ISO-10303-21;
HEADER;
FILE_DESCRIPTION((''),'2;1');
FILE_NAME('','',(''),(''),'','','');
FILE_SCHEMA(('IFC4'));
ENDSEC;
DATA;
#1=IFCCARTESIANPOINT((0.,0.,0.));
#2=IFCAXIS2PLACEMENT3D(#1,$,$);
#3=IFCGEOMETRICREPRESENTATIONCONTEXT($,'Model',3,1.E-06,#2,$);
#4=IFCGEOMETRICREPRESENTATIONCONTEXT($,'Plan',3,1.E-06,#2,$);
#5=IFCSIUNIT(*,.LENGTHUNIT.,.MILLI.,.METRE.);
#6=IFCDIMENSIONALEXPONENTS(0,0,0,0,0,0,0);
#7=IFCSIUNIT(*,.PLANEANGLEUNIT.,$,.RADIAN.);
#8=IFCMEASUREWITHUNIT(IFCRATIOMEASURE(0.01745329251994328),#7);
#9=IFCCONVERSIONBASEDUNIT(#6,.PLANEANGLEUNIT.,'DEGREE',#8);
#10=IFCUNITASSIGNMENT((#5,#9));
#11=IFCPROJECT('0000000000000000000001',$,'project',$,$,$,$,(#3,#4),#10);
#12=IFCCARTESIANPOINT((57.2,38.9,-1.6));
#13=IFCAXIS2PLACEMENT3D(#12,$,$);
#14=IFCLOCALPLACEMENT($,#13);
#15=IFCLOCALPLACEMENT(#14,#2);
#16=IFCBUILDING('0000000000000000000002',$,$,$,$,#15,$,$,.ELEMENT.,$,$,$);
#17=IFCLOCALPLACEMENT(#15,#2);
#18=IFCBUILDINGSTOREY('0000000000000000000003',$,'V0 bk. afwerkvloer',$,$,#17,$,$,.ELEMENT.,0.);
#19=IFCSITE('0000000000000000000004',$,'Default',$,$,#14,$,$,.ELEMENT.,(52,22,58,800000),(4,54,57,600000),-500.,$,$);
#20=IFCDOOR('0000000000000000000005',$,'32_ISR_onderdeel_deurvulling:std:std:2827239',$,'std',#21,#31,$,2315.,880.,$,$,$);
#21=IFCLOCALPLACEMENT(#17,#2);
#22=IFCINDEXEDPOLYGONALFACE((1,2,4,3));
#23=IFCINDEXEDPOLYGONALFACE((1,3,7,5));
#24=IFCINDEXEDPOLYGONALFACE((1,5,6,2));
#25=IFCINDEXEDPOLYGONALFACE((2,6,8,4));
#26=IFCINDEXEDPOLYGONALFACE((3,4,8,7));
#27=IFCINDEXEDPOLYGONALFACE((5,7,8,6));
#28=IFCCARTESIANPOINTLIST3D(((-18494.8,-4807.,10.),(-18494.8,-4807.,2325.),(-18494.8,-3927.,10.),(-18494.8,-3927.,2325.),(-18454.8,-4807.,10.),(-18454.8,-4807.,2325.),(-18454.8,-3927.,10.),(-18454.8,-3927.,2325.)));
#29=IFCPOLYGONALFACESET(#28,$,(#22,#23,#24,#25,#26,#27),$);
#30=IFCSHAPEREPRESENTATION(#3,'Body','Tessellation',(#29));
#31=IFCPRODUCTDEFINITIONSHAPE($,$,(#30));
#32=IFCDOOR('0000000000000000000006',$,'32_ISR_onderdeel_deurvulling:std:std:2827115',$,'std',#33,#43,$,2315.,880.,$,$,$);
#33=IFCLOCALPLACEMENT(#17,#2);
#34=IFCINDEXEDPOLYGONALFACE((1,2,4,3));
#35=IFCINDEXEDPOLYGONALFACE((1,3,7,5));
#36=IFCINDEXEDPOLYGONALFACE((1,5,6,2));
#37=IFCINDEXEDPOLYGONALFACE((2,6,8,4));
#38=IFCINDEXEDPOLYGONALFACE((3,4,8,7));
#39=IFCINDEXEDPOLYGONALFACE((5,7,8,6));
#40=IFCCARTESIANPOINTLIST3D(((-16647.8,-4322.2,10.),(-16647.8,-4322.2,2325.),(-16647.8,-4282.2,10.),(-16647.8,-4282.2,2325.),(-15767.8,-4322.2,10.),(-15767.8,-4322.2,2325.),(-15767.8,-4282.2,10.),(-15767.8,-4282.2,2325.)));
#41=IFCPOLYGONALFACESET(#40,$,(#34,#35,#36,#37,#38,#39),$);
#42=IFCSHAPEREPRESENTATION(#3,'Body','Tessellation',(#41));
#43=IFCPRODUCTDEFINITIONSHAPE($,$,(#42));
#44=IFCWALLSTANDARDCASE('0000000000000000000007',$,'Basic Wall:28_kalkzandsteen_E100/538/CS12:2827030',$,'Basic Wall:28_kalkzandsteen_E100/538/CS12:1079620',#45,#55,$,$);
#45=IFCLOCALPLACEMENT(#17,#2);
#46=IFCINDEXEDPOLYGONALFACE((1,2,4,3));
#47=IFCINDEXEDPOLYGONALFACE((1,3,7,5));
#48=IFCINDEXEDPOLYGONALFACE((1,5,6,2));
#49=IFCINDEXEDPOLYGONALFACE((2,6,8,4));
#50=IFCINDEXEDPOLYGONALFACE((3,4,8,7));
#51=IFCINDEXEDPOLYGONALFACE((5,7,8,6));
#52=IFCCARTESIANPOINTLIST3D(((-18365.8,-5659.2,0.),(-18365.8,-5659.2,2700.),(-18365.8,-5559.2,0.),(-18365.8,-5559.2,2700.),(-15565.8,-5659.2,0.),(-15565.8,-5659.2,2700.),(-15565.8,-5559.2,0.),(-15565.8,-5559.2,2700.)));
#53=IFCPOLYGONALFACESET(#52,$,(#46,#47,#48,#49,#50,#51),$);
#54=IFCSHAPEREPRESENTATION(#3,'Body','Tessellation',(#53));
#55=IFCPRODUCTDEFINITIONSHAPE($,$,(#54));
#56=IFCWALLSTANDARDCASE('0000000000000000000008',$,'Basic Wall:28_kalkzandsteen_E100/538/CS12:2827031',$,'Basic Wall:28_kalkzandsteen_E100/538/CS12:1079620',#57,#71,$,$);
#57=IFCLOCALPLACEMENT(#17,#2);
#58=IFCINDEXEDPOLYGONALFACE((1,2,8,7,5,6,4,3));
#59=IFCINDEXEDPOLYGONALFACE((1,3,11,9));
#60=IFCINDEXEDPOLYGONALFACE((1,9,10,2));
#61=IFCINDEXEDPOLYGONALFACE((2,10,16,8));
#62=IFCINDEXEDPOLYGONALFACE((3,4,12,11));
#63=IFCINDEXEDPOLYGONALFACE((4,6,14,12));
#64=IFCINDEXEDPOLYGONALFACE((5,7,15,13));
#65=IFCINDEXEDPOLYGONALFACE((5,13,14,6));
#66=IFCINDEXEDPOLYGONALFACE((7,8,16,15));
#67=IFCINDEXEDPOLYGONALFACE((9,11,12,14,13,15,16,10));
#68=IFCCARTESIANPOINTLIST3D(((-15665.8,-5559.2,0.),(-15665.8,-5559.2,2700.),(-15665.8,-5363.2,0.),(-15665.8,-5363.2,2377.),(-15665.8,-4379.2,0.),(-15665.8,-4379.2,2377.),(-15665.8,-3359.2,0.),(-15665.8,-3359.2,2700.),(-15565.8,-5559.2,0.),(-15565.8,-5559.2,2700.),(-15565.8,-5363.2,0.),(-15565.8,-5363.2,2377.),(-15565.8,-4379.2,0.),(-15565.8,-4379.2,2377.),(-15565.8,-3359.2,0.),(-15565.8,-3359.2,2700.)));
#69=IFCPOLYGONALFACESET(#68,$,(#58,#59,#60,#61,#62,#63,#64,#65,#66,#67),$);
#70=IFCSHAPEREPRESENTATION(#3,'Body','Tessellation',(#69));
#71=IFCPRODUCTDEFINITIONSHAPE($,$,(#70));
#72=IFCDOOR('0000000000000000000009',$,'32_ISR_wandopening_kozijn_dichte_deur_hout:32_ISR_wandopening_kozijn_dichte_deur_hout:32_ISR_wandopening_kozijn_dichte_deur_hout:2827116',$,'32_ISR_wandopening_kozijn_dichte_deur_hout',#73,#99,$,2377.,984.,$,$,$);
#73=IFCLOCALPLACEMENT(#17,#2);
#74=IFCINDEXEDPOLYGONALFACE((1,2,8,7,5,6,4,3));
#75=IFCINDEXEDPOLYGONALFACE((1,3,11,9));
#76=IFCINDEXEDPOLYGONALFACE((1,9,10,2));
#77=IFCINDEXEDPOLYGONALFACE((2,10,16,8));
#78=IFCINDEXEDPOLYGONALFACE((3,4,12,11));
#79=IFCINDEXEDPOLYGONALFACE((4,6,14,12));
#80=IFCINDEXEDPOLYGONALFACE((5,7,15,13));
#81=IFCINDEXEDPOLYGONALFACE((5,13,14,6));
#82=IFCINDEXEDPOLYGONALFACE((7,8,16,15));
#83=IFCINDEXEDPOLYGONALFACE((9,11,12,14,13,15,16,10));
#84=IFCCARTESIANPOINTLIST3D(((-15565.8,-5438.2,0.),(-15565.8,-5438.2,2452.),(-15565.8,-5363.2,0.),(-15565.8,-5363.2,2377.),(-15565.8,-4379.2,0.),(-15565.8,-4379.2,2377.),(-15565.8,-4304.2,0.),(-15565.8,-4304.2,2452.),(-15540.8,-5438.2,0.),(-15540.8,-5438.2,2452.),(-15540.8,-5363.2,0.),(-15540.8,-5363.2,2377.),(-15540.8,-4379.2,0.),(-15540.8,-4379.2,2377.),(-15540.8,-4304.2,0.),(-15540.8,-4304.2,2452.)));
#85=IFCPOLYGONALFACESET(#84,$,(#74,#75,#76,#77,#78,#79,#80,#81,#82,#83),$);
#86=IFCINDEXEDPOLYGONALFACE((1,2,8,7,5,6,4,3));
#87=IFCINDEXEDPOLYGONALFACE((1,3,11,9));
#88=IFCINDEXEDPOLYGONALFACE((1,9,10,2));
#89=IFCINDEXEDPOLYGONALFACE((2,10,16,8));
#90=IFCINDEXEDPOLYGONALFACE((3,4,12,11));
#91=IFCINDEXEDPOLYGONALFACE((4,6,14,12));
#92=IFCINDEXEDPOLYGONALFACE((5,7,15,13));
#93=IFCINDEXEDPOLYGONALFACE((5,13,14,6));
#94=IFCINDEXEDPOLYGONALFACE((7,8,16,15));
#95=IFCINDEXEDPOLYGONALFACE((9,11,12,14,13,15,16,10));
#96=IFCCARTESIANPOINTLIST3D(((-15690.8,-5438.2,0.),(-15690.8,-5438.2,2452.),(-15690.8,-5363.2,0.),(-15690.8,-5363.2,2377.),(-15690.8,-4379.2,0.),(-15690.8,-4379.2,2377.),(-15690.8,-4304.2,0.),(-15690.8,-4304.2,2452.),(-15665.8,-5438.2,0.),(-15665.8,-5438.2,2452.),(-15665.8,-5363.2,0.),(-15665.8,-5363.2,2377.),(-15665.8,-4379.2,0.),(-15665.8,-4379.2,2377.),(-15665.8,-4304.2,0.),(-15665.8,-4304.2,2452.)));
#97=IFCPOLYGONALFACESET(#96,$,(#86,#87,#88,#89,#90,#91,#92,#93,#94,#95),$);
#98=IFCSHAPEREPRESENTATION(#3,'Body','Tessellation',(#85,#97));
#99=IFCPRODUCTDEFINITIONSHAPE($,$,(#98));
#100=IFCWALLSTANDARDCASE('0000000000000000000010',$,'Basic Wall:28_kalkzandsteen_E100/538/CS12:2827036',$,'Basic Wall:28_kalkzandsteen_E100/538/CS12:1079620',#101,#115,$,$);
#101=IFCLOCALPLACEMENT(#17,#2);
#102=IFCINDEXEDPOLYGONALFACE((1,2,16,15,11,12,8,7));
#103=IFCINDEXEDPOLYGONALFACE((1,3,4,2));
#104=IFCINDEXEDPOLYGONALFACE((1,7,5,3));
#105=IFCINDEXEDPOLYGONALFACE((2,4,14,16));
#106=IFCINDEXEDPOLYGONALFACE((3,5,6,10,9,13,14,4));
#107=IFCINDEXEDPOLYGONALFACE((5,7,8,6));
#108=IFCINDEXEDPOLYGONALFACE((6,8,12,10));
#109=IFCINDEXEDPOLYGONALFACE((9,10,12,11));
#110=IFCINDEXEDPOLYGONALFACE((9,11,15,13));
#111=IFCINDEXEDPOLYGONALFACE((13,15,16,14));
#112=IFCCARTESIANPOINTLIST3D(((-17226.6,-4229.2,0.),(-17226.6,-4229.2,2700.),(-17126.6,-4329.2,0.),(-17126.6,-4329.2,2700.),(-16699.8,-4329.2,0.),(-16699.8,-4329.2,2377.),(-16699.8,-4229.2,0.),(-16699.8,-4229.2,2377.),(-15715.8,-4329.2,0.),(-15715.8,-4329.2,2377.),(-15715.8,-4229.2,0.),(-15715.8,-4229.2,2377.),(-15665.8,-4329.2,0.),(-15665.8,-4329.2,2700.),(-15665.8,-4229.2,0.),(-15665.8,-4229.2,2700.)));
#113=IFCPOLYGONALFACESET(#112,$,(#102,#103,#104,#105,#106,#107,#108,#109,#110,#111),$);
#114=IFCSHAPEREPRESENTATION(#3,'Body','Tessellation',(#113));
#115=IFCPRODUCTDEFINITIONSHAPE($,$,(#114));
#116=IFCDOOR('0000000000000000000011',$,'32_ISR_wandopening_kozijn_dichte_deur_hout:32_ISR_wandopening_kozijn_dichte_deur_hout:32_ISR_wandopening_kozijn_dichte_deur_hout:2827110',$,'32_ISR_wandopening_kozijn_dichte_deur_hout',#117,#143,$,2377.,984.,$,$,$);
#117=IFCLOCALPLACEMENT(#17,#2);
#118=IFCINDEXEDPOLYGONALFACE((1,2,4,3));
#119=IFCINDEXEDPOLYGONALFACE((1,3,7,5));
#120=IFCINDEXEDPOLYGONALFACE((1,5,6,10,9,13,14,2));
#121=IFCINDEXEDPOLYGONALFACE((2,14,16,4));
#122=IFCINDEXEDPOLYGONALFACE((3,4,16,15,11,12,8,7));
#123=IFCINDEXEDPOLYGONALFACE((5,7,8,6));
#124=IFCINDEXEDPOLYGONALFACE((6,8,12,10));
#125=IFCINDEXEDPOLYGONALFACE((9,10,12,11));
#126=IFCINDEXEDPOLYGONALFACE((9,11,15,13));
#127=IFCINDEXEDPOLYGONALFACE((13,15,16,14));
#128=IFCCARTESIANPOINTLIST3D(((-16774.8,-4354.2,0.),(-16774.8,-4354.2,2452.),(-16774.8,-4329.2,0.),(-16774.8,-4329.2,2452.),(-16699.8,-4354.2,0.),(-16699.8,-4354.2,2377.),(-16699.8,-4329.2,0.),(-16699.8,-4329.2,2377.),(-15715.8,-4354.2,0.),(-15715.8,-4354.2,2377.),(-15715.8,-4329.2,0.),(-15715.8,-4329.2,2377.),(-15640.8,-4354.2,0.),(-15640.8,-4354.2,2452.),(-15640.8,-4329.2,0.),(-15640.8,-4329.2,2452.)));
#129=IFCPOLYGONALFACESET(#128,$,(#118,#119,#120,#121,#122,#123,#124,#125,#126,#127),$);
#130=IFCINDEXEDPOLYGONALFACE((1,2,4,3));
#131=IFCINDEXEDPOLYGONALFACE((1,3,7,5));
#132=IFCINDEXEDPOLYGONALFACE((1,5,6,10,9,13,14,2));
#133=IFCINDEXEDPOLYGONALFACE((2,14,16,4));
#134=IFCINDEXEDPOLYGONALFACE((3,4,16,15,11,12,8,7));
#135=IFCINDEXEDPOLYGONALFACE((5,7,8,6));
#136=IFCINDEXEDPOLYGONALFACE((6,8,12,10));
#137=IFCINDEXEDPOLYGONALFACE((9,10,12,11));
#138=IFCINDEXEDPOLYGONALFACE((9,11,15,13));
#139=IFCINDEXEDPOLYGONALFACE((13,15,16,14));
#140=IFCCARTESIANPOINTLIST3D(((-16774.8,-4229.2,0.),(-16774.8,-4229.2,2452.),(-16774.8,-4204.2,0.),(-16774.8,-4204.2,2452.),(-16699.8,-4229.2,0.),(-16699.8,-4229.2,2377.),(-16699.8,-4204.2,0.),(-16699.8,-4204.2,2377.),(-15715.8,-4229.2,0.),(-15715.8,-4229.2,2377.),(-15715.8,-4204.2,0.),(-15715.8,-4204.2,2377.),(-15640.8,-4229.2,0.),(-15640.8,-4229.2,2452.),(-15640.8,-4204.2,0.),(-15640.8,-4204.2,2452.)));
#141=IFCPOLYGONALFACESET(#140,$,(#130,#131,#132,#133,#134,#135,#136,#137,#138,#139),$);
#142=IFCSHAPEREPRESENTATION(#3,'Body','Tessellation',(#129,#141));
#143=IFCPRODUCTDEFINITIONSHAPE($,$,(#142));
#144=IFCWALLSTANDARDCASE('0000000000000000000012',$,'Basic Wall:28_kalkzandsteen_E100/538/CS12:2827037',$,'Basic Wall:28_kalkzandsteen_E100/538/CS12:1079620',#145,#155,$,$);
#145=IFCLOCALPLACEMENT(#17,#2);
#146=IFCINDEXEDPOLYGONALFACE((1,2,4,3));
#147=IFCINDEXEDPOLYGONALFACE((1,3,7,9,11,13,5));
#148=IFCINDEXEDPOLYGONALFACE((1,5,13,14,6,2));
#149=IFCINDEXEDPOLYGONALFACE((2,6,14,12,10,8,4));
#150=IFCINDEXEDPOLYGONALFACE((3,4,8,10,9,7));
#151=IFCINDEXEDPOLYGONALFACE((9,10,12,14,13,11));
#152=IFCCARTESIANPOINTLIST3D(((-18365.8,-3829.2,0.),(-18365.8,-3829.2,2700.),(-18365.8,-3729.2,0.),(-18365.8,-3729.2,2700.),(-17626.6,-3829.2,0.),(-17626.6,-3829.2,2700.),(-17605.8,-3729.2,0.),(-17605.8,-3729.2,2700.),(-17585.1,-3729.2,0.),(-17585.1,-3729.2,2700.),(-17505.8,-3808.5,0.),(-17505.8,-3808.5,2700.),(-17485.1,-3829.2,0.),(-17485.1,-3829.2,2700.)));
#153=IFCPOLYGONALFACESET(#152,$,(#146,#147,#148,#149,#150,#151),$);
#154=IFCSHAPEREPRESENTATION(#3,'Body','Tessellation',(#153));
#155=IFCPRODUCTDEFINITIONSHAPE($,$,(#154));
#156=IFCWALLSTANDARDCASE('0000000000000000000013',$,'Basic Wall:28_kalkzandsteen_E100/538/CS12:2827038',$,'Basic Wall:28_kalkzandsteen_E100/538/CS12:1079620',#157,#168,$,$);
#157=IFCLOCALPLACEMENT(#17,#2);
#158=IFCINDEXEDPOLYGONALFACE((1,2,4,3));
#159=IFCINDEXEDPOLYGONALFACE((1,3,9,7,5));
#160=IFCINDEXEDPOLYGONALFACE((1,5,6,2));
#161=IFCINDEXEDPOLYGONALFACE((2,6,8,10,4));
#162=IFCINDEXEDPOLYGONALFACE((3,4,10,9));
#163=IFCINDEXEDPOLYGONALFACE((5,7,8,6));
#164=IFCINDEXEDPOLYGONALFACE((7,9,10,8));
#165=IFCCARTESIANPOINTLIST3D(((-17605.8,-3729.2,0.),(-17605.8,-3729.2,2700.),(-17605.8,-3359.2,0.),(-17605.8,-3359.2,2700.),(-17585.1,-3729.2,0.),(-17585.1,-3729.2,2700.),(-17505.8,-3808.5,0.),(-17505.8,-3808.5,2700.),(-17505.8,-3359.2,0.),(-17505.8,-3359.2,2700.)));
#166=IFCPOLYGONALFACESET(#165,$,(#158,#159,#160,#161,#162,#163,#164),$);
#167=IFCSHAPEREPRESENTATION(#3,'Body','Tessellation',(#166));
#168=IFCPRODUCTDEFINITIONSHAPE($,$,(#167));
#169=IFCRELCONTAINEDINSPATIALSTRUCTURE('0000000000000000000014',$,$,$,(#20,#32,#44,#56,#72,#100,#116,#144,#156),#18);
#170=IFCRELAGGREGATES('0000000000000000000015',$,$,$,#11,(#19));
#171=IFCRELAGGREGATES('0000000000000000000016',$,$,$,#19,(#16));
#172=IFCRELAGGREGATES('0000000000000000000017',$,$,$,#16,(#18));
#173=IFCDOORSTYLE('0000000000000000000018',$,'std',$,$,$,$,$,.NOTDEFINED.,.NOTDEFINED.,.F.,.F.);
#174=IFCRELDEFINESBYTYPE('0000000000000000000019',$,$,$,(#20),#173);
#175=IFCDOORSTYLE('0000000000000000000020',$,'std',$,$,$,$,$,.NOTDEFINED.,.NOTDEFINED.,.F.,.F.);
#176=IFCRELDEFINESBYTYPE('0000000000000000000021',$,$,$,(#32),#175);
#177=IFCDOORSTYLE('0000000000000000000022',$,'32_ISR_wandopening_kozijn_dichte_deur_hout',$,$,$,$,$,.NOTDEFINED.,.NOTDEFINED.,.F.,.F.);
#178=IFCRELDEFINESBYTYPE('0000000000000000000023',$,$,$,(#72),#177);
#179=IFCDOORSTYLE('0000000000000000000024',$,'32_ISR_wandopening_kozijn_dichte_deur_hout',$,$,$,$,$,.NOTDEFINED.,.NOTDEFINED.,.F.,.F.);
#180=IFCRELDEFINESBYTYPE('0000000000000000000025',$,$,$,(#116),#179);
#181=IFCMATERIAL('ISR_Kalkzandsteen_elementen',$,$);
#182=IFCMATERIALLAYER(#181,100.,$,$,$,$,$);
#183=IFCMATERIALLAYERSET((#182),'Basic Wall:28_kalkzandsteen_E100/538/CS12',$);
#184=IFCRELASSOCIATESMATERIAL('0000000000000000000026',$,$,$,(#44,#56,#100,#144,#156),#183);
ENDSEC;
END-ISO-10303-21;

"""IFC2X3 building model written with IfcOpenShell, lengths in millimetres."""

from ifc_helpers import new_model, entity, si_unit, converted_unit, frame, frame_2d, origin, origin_2d_with_axis, place, context, project, spatial, polyline, rectangle, outline, extrude, source, transform, mapped, material, layer, layer_set, layer_usage, type_object, type_shapes, element, fill, save


model = new_model("IFC2X3")

# Units and contexts
model_context = context("Model", 3, precision=1e-06, world=origin())
plan_context = context("Plan", 3, precision=1e-06, world=origin())
ifc_project = project(units=[si_unit("LENGTHUNIT", "METRE", prefix="MILLI"), converted_unit("PLANEANGLEUNIT", "DEGREE", entity("IfcRatioMeasure", 0.01745329251994328), si_unit("PLANEANGLEUNIT", "RADIAN"), dimensions=[0, 0, 0, 0, 0, 0, 0])], contexts=[model_context, plan_context])

# Site, building, storey
site_placement = place(None, frame((57.2, 38.9, -1.6)))
site = spatial("IfcSite", under=ifc_project, at=site_placement, Name="Default", CompositionType="ELEMENT", RefLatitude=(52, 22, 58, 800000), RefLongitude=(4, 54, 57, 600000), RefElevation=-500.0)
building_placement = place(site_placement, origin())
building = spatial("IfcBuilding", under=site, at=building_placement, CompositionType="ELEMENT")
storey_placement = place(building_placement, origin())
storey = spatial("IfcBuildingStorey", under=building, at=storey_placement, Name="V0 bk. afwerkvloer", CompositionType="ELEMENT", Elevation=0.0)

# Doors
door_style_1 = type_object("IfcDoorStyle", Name="std", ConstructionType="NOTDEFINED", OperationType="NOTDEFINED", ParameterTakesPrecedence=False, Sizeable=False)
shared_shape_1 = source(origin(), model_context, "Body", "SweptSolid", [
    extrude(rectangle(XDim=880.0, YDim=40.0, at=origin_2d_with_axis()), frame((0.0, 34.0, 0.0)), (0.0, 0.0, 1.0), 2315.0),
])
type_shapes(door_style_1, [shared_shape_1])
door_1_placement = place(storey_placement, frame((-18440.8, -4367.0, 10.0), z_axis=(0.0, 0.0, 1.0), x_axis=(0.0, 1.0, 0.0)))
element("IfcDoor", 1, at=door_1_placement, inside=storey, type_object=door_style_1, Name="32_ISR_onderdeel_deurvulling:std:std:2827239", ObjectType="std", OverallHeight=2315.0, OverallWidth=880.0, context=model_context, shape_type="MappedRepresentation", body=[
    mapped(shared_shape_1, transform((0.0, 0.0, 0.0), scale=1.0)),
])
door_style_2 = type_object("IfcDoorStyle", Name="std", ConstructionType="NOTDEFINED", OperationType="NOTDEFINED", ParameterTakesPrecedence=False, Sizeable=False)
shared_shape_2 = source(origin(), model_context, "Body", "SweptSolid", [
    extrude(rectangle(XDim=40.0, YDim=880.0, at=origin_2d_with_axis()), frame((0.0, -34.0, 0.0), z_axis=(0.0, 0.0, 1.0), x_axis=(0.0, -1.0, 0.0)), (0.0, 0.0, 1.0), 2315.0),
])
type_shapes(door_style_2, [shared_shape_2])
door_2_placement = place(storey_placement, frame((-16207.8, -4336.2, 10.0), z_axis=(0.0, 0.0, 1.0), x_axis=(-1.0, 0.0, 0.0)))
element("IfcDoor", 2, at=door_2_placement, inside=storey, type_object=door_style_2, Name="32_ISR_onderdeel_deurvulling:std:std:2827115", ObjectType="std", OverallHeight=2315.0, OverallWidth=880.0, context=model_context, shape_type="MappedRepresentation", body=[
    mapped(shared_shape_2, transform((0.0, 0.0, 0.0), scale=1.0)),
])

# Shared definitions
ifc_material_1 = material(Name="ISR_Kalkzandsteen_elementen")
ifc_layer_1 = layer(ifc_material_1, 100.0)
ifc_layer_set_1 = layer_set([ifc_layer_1], Name="Basic Wall:28_kalkzandsteen_E100/538/CS12")

# Wall
ifc_layer_usage_1 = layer_usage(ifc_layer_set_1, "AXIS2", "POSITIVE", -50.0)
wall_1_placement = place(storey_placement, frame((-18365.8, -5609.2, 0.0)))
element("IfcWallStandardCase", 3, at=wall_1_placement, inside=storey, material=ifc_layer_usage_1, Name="Basic Wall:28_kalkzandsteen_E100/538/CS12:2827030", ObjectType="Basic Wall:28_kalkzandsteen_E100/538/CS12:1079620", context=model_context, shape_type="SweptSolid", body=[
    extrude(rectangle(XDim=2800.0, YDim=100.0, at=frame_2d((1400.0, 0.0), x_axis=(-1.0, 0.0))), origin(), (0.0, 0.0, 1.0), 2700.0),
])

# Walls, openings, doors
ifc_layer_usage_2 = layer_usage(ifc_layer_set_1, "AXIS2", "POSITIVE", -50.0)
wall_2_placement = place(storey_placement, frame((-15615.8, -5559.2, 0.0), z_axis=(0.0, 0.0, 1.0), x_axis=(0.0, 1.0, 0.0)))
wall_2 = element("IfcWallStandardCase", 4, at=wall_2_placement, inside=storey, material=ifc_layer_usage_2, Name="Basic Wall:28_kalkzandsteen_E100/538/CS12:2827031", ObjectType="Basic Wall:28_kalkzandsteen_E100/538/CS12:1079620", context=model_context, shape_type="SweptSolid", body=[
    extrude(rectangle(XDim=2200.0, YDim=100.0, at=frame_2d((1100.0, 0.0), x_axis=(-1.0, 0.0))), origin(), (0.0, 0.0, 1.0), 2700.0),
])
opening_1_placement = place(wall_2_placement, frame((1180.0, 50.0, 0.0)))
opening_1 = element("IfcOpeningElement", 5, at=opening_1_placement, cuts=wall_2, ObjectType="Opening", context=model_context, shape_type="SweptSolid", body=[
    extrude(rectangle(XDim=2377.0, YDim=984.0, at=frame_2d((1188.5, 492.0), x_axis=(1.0, 0.0))), frame((0.0, 0.0, 0.0), z_axis=(0.0, -1.0, 0.0), x_axis=(0.0, 0.0, 1.0)), (0.0, 0.0, 1.0), 100.0),
])
door_style_3 = type_object("IfcDoorStyle", Name="32_ISR_wandopening_kozijn_dichte_deur_hout", ConstructionType="NOTDEFINED", OperationType="NOTDEFINED", ParameterTakesPrecedence=False, Sizeable=False)
shared_shape_3 = source(origin(), model_context, "Body", "SweptSolid", [
    extrude(outline(polyline([(-1169.7, 492.0), (1207.2, 492.0), (1207.2, 567.0), (-1244.7, 567.0), (-1244.7, -567.0), (1207.2, -567.0), (1207.2, -492.0), (-1169.7, -492.0), (-1169.7, 492.0)])), frame((1202.0, 125.0, 1207.2), z_axis=(0.0, -1.0, 0.0), x_axis=(0.0, 0.0, -1.0)), (0.0, 0.0, 1.0), 25.0),
    extrude(outline(polyline([(-567.0, -1244.7), (567.0, -1244.7), (567.0, 1207.2), (492.0, 1207.2), (492.0, -1169.7), (-492.0, -1169.7), (-492.0, 1207.2), (-567.0, 1207.2), (-567.0, -1244.7)])), frame((1202.0, 0.0, 1207.2), z_axis=(0.0, -1.0, 0.0), x_axis=(-1.0, 0.0, 0.0)), (0.0, 0.0, 1.0), 25.0),
])
type_shapes(door_style_3, [shared_shape_3])
door_3_placement = place(opening_1_placement, frame((710.0, 0.0, 0.0), z_axis=(0.0, 0.0, 1.0), x_axis=(-1.0, 0.0, 0.0)))
door_3 = element("IfcDoor", 6, at=door_3_placement, inside=storey, type_object=door_style_3, Name="32_ISR_wandopening_kozijn_dichte_deur_hout:32_ISR_wandopening_kozijn_dichte_deur_hout:32_ISR_wandopening_kozijn_dichte_deur_hout:2827116", ObjectType="32_ISR_wandopening_kozijn_dichte_deur_hout", OverallHeight=2377.0, OverallWidth=984.0, context=model_context, shape_type="MappedRepresentation", body=[
    mapped(shared_shape_3, transform((0.0, 0.0, 0.0), scale=1.0)),
])
fill(opening_1, door_3)
ifc_layer_usage_3 = layer_usage(ifc_layer_set_1, "AXIS2", "POSITIVE", -50.0)
wall_3_placement = place(storey_placement, frame((-15665.8, -4279.2, 0.0), z_axis=(0.0, 0.0, 1.0), x_axis=(-1.0, 0.0, 0.0)))
wall_3 = element("IfcWallStandardCase", 7, at=wall_3_placement, inside=storey, material=ifc_layer_usage_3, Name="Basic Wall:28_kalkzandsteen_E100/538/CS12:2827036", ObjectType="Basic Wall:28_kalkzandsteen_E100/538/CS12:1079620", context=model_context, shape_type="SweptSolid", body=[
    extrude(outline(polyline([(0.0, -50.0), (1419.3, -50.0), (1560.7, -50.0), (1460.7, 50.0), (0.0, 50.0), (0.0, -50.0)])), origin(), (0.0, 0.0, 1.0), 2700.0),
])
opening_2_placement = place(wall_3_placement, frame((50.0, -50.0, 0.0)))
opening_2 = element("IfcOpeningElement", 8, at=opening_2_placement, cuts=wall_3, ObjectType="Opening", context=model_context, shape_type="SweptSolid", body=[
    extrude(rectangle(XDim=2377.0, YDim=984.0, at=frame_2d((1188.5, 492.0), x_axis=(1.0, 0.0))), frame((0.0, 0.0, 0.0), z_axis=(0.0, 1.0, 0.0), x_axis=(0.0, 0.0, 1.0)), (0.0, 0.0, 1.0), 100.0),
])
door_style_4 = type_object("IfcDoorStyle", Name="32_ISR_wandopening_kozijn_dichte_deur_hout", ConstructionType="NOTDEFINED", OperationType="NOTDEFINED", ParameterTakesPrecedence=False, Sizeable=False)
shared_shape_4 = source(origin(), model_context, "Body", "SweptSolid", [
    extrude(outline(polyline([(-1169.7, 492.0), (1207.2, 492.0), (1207.2, 567.0), (-1244.7, 567.0), (-1244.7, -567.0), (1207.2, -567.0), (1207.2, -492.0), (-1169.7, -492.0), (-1169.7, 492.0)])), frame((492.0, 100.0, 1207.2), z_axis=(0.0, 1.0, 0.0), x_axis=(0.0, 0.0, -1.0)), (0.0, 0.0, 1.0), 25.0),
    extrude(outline(polyline([(-567.0, -1244.7), (567.0, -1244.7), (567.0, 1207.2), (492.0, 1207.2), (492.0, -1169.7), (-492.0, -1169.7), (-492.0, 1207.2), (-567.0, 1207.2), (-567.0, -1244.7)])), frame((492.0, -25.0, 1207.2), z_axis=(0.0, 1.0, 0.0), x_axis=(1.0, 0.0, 0.0)), (0.0, 0.0, 1.0), 25.0),
])
type_shapes(door_style_4, [shared_shape_4])
door_4_placement = place(opening_2_placement, origin())
door_4 = element("IfcDoor", 9, at=door_4_placement, inside=storey, type_object=door_style_4, Name="32_ISR_wandopening_kozijn_dichte_deur_hout:32_ISR_wandopening_kozijn_dichte_deur_hout:32_ISR_wandopening_kozijn_dichte_deur_hout:2827110", ObjectType="32_ISR_wandopening_kozijn_dichte_deur_hout", OverallHeight=2377.0, OverallWidth=984.0, context=model_context, shape_type="MappedRepresentation", body=[
    mapped(shared_shape_4, transform((0.0, 0.0, 0.0), scale=1.0)),
])
fill(opening_2, door_4)

# Walls
ifc_layer_usage_4 = layer_usage(ifc_layer_set_1, "AXIS2", "NEGATIVE", 50.0)
wall_4_placement = place(storey_placement, frame((-18365.8, -3779.2, 0.0)))
element("IfcWallStandardCase", 10, at=wall_4_placement, inside=storey, material=ifc_layer_usage_4, Name="Basic Wall:28_kalkzandsteen_E100/538/CS12:2827037", ObjectType="Basic Wall:28_kalkzandsteen_E100/538/CS12:1079620", context=model_context, shape_type="SweptSolid", body=[
    extrude(outline(polyline([(880.7, -50.0), (860.0, -29.3), (780.7, 50.0), (760.0, 50.0), (0.0, 50.0), (0.0, -50.0), (739.3, -50.0), (880.7, -50.0)])), origin(), (0.0, 0.0, 1.0), 2700.0),
])
ifc_layer_usage_5 = layer_usage(ifc_layer_set_1, "AXIS2", "POSITIVE", -50.0)
wall_5_placement = place(storey_placement, frame((-17555.8, -3359.2, 0.0), z_axis=(0.0, 0.0, 1.0), x_axis=(0.0, -1.0, 0.0)))
element("IfcWallStandardCase", 11, at=wall_5_placement, inside=storey, material=ifc_layer_usage_5, Name="Basic Wall:28_kalkzandsteen_E100/538/CS12:2827038", ObjectType="Basic Wall:28_kalkzandsteen_E100/538/CS12:1079620", context=model_context, shape_type="SweptSolid", body=[
    extrude(outline(polyline([(370.0, -50.0), (370.0, -29.3), (449.3, 50.0), (0.0, 50.0), (0.0, -50.0), (370.0, -50.0)])), origin(), (0.0, 0.0, 1.0), 2700.0),
])

save(model, "model.ifc")
